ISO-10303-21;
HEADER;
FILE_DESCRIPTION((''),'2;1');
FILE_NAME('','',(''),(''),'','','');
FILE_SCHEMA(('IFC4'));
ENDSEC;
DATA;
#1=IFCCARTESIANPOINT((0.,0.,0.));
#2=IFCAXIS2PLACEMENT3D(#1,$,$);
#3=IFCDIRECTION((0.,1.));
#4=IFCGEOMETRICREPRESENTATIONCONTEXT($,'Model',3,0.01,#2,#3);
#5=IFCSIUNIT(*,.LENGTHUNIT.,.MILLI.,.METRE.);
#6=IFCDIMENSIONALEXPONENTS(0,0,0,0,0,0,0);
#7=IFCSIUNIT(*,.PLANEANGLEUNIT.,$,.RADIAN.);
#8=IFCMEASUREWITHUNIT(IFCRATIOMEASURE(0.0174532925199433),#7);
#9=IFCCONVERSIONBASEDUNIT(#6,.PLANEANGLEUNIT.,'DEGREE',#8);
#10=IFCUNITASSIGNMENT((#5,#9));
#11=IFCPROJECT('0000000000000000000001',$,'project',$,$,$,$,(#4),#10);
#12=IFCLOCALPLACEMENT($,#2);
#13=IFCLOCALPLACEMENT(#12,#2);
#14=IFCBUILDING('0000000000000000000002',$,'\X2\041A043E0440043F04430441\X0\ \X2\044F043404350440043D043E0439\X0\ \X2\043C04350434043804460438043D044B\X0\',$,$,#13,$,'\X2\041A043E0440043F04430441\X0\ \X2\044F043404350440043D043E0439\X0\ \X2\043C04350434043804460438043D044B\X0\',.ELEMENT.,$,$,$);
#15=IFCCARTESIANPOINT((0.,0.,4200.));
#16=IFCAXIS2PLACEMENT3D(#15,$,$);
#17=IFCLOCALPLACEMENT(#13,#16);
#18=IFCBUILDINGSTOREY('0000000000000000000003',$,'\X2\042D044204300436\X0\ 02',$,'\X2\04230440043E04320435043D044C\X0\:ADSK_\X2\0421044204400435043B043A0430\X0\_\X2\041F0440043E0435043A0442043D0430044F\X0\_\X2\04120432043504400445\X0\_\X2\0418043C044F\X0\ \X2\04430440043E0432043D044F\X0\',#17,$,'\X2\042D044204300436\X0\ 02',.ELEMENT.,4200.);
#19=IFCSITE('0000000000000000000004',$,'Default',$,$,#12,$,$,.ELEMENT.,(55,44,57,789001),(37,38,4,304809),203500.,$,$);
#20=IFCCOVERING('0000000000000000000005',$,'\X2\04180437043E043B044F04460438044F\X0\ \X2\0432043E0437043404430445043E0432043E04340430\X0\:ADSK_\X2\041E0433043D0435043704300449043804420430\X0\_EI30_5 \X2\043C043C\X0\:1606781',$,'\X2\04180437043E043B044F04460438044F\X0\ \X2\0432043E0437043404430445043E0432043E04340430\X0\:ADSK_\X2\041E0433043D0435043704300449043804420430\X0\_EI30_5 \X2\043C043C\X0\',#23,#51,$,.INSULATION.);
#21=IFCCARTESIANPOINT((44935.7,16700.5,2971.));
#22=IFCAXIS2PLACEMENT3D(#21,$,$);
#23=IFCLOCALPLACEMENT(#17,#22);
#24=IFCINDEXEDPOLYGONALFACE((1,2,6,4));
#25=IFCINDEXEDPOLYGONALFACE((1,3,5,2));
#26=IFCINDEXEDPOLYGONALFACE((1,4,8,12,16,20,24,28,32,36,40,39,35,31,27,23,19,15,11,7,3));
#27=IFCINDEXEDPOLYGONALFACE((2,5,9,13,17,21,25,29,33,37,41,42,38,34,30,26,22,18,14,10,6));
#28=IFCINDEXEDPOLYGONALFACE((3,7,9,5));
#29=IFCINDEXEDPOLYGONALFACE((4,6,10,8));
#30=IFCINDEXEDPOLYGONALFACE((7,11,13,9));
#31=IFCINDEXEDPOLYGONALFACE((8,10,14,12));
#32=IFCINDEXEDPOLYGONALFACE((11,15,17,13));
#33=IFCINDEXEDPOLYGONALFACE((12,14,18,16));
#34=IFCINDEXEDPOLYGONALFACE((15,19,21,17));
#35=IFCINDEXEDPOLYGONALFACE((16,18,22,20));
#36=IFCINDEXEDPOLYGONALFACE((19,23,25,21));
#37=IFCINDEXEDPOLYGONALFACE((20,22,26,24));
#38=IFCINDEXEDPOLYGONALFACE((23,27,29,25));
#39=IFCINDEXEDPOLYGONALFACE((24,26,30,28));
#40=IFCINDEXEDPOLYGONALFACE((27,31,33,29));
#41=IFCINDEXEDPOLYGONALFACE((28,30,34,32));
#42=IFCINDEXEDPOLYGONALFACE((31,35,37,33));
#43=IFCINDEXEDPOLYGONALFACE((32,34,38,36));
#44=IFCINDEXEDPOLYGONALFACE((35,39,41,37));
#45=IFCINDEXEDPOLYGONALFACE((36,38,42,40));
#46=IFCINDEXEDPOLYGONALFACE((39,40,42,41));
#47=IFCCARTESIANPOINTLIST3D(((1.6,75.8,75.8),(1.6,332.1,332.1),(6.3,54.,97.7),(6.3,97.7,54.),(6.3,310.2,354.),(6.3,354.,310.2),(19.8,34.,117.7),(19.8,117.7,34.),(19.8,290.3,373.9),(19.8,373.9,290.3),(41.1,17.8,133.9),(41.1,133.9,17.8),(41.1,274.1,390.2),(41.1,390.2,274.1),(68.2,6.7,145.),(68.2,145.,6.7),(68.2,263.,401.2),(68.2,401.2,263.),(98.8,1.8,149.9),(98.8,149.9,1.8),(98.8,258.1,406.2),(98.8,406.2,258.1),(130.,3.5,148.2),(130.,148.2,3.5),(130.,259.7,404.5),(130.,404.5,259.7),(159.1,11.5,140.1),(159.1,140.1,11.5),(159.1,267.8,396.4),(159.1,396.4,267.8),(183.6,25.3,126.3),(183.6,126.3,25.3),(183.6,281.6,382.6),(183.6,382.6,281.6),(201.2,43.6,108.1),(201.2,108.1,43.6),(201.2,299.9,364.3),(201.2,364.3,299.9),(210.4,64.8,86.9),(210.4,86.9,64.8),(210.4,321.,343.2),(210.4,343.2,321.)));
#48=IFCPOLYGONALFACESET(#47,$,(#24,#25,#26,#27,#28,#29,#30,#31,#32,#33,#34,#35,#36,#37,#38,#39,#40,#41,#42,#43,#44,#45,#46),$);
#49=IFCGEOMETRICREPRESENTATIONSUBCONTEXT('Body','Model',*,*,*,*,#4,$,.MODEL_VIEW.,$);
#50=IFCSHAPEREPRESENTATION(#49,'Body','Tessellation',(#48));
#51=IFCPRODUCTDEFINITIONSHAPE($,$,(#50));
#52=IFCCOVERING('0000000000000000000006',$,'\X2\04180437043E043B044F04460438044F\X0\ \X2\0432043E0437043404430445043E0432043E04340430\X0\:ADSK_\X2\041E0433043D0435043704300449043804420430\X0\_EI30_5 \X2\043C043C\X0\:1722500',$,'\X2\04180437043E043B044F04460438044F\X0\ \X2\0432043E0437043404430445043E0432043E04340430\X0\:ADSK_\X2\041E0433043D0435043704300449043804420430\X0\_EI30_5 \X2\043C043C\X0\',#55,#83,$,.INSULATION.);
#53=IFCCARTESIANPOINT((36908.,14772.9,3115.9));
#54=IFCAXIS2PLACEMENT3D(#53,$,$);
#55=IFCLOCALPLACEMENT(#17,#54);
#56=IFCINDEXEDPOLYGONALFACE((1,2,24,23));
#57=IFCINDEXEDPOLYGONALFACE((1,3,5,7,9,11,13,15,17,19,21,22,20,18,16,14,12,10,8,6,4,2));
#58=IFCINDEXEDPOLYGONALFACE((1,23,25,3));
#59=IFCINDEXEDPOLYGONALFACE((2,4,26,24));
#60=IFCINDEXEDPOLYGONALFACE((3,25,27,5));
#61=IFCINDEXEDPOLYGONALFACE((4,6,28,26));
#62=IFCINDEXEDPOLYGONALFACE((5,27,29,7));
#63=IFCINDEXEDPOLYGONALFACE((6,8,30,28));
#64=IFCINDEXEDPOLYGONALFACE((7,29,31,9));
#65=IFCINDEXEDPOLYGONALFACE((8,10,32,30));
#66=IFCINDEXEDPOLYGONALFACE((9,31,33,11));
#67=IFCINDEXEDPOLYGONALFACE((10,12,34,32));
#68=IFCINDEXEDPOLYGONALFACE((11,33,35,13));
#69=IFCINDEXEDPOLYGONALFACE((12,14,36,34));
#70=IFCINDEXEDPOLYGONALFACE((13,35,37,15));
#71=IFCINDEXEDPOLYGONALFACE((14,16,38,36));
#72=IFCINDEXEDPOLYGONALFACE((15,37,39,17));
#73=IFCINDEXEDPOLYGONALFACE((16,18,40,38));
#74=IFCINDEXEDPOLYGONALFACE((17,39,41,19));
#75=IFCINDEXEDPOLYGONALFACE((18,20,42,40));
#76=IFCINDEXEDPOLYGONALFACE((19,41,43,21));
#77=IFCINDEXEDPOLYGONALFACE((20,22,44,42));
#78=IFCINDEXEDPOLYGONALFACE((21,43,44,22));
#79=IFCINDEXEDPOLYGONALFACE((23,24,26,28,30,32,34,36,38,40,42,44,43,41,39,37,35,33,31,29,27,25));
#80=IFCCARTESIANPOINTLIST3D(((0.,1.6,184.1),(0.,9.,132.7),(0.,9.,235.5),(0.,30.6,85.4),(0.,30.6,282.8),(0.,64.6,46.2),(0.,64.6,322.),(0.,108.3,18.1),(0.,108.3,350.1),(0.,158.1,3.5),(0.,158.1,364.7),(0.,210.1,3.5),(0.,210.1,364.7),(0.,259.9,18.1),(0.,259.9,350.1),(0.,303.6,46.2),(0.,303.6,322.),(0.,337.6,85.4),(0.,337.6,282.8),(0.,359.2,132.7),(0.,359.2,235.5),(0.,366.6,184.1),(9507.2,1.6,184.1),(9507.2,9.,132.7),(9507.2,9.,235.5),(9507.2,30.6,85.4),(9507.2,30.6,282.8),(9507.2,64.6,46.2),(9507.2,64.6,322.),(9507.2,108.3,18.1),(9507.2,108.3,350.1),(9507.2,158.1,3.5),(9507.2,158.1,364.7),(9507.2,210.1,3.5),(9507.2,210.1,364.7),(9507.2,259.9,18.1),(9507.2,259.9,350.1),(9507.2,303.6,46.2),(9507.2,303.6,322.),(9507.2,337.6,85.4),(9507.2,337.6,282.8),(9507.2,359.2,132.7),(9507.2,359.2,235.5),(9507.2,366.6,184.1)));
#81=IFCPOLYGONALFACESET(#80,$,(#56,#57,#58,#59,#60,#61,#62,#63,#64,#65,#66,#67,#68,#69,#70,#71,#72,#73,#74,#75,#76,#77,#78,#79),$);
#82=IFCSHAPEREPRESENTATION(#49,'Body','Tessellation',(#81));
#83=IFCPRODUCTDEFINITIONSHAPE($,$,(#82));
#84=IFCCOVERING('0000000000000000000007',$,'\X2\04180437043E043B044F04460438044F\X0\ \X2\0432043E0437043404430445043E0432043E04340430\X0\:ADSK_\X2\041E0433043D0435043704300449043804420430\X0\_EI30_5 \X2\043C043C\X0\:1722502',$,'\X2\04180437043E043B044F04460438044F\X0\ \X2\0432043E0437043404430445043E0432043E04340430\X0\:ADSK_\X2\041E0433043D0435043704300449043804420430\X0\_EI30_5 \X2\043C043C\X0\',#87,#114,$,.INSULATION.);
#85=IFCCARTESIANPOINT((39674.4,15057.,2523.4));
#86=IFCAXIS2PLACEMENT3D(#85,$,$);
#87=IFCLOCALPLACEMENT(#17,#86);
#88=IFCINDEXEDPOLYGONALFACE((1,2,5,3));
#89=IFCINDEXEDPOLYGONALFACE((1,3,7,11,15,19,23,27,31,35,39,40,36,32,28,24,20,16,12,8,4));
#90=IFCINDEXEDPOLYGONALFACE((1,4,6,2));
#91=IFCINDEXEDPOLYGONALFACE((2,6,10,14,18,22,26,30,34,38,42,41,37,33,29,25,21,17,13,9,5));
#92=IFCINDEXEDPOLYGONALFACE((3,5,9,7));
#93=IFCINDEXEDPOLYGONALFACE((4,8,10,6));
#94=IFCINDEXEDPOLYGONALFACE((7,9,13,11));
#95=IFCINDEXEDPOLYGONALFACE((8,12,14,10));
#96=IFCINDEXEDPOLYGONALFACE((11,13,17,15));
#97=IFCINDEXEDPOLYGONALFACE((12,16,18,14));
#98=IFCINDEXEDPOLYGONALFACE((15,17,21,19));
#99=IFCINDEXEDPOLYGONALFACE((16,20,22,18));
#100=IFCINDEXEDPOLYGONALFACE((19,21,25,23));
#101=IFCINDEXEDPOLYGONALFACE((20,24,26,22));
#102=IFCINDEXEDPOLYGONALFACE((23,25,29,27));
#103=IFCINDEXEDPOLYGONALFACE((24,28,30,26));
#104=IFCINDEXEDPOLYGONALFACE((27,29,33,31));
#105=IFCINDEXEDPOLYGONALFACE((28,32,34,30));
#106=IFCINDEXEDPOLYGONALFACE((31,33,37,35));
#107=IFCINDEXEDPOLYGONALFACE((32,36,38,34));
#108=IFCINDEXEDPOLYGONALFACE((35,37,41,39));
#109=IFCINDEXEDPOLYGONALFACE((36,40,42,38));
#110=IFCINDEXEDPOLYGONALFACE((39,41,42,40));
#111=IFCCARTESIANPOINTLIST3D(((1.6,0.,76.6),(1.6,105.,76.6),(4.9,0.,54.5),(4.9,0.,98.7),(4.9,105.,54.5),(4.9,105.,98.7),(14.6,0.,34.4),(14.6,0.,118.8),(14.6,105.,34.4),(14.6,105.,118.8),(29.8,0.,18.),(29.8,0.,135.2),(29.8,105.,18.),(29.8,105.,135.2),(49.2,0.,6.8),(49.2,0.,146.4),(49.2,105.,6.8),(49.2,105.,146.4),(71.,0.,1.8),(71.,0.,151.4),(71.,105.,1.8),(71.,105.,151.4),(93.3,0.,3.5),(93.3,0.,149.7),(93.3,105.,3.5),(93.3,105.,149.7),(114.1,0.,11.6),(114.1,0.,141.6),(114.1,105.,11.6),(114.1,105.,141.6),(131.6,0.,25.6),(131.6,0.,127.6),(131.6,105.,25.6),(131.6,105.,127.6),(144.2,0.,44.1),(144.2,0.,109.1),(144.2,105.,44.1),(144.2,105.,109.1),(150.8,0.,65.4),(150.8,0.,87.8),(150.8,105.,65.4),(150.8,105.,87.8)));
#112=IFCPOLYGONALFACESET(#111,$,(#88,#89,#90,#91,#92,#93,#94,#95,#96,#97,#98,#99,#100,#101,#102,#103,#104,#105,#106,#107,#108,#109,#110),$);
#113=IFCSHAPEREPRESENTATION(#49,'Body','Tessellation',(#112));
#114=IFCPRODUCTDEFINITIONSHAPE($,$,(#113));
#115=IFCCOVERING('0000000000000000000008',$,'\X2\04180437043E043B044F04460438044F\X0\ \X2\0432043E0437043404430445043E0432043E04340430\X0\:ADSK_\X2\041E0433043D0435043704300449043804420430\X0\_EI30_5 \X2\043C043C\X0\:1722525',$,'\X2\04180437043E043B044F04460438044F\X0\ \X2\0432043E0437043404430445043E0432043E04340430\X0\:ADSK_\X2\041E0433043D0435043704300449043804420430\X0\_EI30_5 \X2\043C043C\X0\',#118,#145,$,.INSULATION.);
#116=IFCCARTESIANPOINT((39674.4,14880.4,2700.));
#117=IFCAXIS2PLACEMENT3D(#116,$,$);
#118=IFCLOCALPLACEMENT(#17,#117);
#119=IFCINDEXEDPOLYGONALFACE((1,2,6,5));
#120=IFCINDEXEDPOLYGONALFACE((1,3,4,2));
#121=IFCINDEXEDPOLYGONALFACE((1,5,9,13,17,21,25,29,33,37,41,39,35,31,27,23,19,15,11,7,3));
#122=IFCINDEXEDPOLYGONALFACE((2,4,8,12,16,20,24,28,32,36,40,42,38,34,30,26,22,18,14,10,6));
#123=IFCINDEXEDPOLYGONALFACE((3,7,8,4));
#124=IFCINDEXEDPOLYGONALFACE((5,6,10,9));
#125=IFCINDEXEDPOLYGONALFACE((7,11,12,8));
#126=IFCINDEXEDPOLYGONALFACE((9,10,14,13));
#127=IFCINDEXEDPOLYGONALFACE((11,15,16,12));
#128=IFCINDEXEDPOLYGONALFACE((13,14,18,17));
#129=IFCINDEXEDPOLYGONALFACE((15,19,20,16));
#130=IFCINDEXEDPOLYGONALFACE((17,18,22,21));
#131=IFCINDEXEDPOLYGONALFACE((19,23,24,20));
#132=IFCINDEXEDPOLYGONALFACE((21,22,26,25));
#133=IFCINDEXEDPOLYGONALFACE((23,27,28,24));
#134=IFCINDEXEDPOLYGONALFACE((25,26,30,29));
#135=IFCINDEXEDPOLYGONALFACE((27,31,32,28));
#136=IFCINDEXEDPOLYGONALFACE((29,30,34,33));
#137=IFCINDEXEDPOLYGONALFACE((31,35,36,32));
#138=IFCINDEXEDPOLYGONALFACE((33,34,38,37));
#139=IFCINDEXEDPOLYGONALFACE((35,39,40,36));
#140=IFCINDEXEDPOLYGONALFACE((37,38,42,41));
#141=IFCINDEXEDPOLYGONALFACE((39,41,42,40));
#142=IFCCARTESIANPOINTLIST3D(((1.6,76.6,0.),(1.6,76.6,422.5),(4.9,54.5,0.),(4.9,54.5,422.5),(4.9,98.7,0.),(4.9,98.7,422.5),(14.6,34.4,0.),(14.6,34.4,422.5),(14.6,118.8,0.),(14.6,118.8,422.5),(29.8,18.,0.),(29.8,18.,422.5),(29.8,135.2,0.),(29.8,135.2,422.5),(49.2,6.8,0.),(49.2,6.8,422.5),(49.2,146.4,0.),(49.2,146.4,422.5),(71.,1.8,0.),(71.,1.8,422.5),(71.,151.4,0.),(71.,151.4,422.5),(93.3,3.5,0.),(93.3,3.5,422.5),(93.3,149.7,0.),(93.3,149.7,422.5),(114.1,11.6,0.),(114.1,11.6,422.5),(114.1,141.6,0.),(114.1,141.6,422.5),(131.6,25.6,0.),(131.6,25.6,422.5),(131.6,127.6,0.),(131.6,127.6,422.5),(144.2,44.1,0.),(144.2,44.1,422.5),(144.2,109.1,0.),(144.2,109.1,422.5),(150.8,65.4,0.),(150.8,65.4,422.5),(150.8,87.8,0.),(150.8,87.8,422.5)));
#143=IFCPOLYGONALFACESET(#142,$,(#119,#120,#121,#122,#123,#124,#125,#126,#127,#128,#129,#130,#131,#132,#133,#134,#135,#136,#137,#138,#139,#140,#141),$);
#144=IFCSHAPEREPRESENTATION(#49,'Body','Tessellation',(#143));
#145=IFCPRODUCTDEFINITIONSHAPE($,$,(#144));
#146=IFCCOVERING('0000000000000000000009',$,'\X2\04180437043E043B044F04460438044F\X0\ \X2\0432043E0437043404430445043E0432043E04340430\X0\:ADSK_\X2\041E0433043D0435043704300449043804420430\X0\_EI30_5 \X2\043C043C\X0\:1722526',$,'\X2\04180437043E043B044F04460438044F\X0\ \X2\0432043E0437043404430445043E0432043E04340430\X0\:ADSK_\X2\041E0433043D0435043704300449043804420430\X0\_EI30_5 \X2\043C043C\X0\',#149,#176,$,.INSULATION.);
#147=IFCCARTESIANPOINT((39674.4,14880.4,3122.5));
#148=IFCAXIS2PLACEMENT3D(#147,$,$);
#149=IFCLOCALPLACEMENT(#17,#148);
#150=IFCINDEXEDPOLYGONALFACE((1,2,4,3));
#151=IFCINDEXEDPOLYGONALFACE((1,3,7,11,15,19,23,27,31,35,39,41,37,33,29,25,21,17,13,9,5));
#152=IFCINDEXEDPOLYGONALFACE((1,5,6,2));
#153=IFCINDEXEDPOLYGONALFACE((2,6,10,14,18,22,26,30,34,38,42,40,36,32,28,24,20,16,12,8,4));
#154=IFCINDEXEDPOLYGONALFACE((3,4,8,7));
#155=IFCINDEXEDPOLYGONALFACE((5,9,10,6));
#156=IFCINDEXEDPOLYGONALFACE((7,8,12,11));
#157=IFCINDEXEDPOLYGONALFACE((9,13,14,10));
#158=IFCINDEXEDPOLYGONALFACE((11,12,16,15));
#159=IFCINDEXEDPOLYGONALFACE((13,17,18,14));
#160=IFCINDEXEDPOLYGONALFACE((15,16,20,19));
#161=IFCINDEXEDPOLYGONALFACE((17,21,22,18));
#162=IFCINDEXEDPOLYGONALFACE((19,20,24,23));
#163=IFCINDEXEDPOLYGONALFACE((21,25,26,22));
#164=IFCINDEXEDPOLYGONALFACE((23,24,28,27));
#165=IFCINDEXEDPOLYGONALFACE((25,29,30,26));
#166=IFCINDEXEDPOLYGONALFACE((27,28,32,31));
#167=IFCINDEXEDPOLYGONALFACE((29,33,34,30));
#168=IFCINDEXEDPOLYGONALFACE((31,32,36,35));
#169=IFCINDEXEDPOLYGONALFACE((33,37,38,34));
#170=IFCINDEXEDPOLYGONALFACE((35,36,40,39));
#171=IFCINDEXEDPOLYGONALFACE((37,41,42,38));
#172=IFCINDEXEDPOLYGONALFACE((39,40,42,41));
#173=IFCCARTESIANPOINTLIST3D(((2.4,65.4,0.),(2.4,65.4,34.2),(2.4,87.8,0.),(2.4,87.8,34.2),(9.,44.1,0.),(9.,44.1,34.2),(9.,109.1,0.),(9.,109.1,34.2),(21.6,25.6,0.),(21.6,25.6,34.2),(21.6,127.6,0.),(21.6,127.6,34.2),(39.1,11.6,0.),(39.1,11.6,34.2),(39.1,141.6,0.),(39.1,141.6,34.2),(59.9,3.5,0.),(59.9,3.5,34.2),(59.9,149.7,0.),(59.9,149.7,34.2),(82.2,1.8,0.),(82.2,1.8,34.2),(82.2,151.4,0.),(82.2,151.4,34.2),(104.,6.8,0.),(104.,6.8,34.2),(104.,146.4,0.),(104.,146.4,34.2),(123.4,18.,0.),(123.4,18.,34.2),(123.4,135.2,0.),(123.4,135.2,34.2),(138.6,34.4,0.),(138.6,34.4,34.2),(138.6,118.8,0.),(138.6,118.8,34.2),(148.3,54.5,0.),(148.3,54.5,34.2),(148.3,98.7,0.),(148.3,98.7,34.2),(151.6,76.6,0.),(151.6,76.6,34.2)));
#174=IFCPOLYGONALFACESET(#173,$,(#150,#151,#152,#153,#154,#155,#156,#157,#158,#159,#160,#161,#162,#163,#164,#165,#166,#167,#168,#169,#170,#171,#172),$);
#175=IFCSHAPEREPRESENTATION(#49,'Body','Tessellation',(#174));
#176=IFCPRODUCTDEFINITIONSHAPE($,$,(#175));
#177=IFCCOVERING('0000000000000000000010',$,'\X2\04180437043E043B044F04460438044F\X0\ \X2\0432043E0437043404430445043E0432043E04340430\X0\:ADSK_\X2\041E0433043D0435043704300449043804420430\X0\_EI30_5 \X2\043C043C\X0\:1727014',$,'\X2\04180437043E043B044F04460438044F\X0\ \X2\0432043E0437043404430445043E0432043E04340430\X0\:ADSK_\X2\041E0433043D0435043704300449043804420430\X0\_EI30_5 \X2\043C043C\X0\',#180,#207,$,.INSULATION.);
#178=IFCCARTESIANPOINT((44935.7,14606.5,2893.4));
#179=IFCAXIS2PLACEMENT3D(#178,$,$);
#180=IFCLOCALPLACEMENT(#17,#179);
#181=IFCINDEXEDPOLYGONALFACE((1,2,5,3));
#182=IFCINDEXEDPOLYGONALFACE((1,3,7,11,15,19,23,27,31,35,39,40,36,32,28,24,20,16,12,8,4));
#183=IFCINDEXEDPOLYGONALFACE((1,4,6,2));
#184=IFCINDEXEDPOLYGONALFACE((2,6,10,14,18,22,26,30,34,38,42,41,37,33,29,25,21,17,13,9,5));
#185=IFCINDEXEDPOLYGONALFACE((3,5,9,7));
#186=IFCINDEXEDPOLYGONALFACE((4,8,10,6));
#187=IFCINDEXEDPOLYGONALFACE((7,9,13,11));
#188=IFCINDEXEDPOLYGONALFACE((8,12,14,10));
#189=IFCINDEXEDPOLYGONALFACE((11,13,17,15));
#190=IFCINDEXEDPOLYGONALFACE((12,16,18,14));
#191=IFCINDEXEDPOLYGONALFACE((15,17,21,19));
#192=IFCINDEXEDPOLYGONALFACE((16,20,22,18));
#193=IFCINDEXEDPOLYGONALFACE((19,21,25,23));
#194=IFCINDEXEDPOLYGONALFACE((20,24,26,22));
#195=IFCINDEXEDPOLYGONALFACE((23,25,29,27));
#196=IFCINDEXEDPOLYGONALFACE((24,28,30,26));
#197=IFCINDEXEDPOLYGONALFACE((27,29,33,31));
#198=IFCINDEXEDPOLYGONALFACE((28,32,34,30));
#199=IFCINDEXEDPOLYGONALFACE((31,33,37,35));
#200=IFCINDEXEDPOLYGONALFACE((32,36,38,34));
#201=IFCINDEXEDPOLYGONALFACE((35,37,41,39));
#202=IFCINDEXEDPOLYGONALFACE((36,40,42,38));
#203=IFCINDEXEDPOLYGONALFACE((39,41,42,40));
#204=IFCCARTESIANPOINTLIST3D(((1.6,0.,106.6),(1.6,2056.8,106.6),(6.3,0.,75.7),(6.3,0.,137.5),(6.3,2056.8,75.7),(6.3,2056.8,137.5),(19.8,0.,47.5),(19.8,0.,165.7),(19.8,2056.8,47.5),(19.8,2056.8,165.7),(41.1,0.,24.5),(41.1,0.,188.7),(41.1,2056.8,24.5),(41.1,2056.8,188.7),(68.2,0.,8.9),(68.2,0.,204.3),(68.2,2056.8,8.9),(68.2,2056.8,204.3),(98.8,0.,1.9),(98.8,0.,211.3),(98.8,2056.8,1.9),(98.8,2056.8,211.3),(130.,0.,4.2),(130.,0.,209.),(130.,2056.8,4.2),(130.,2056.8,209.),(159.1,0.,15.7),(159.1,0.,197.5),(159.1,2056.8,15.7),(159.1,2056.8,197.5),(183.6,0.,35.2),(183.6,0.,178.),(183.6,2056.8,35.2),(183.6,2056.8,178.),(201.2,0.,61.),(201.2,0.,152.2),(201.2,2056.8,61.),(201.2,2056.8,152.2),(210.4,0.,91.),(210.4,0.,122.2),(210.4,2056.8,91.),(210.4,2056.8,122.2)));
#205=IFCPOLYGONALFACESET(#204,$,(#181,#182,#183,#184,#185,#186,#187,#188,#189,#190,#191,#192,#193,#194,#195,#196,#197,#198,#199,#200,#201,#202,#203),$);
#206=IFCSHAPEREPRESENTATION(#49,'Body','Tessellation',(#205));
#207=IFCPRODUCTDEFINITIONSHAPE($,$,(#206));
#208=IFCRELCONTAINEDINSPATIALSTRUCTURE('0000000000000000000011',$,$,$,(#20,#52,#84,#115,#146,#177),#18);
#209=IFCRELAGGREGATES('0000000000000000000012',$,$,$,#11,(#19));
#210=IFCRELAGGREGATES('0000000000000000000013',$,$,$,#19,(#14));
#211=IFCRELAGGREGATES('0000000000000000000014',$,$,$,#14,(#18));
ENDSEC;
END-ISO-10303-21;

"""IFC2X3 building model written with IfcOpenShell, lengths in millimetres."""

from ifc_helpers import new_model, entity, si_unit, converted_unit, direction, frame, origin, origin_2d_with_axis, place, context, subcontext, project, spatial, circle, extrude, element, save


model = new_model("IFC2X3")

# Units and contexts
model_context = context("Model", 3, precision=0.01, world=origin(), true_north=direction((0.0, 1.0)))
body_context = subcontext(model_context, "Body", "Model", "MODEL_VIEW")
ifc_project = project(units=[si_unit("LENGTHUNIT", "METRE", prefix="MILLI"), converted_unit("PLANEANGLEUNIT", "DEGREE", entity("IfcRatioMeasure", 0.0174532925199433), si_unit("PLANEANGLEUNIT", "RADIAN"), dimensions=[0, 0, 0, 0, 0, 0, 0])], contexts=[model_context])

# Site, building, storey
site_placement = place(None, origin())
site = spatial("IfcSite", under=ifc_project, at=site_placement, Name="Default", CompositionType="ELEMENT", RefLatitude=(55, 44, 57, 789001), RefLongitude=(37, 38, 4, 304809), RefElevation=203500.0)
building_placement = place(site_placement, origin())
building = spatial("IfcBuilding", under=site, at=building_placement, Name="Корпус ядерной медицины", LongName="Корпус ядерной медицины", CompositionType="ELEMENT")
storey_placement = place(building_placement, frame((0.0, 0.0, 4200.0)))
storey = spatial("IfcBuildingStorey", under=building, at=storey_placement, Name="Этаж 02", ObjectType="Уровень:ADSK_Стрелка_Проектная_Вверх_Имя уровня", LongName="Этаж 02", CompositionType="ELEMENT", Elevation=4200.0)

# Coverings
covering_1_placement = place(storey_placement, frame((44935.7, 16700.5, 2971.0)))
element("IfcCovering", 1, at=covering_1_placement, inside=storey, Name="Изоляция воздуховода:ADSK_Огнезащита_EI30_5 мм:1606781", ObjectType="Изоляция воздуховода:ADSK_Огнезащита_EI30_5 мм", PredefinedType="INSULATION", context=body_context, shape_type="SweptSolid", body=[
    extrude(circle(Radius=105.0, at=origin_2d_with_axis()), frame((106.6, 75.8, 75.8), z_axis=(0.0, 0.707107, 0.707107), x_axis=(-1.0, 0.0, 0.0)), (0.0, 0.0, 1.0), 362.4),
])
covering_2_placement = place(storey_placement, frame((36908.0, 14772.9, 3115.9)))
element("IfcCovering", 2, at=covering_2_placement, inside=storey, Name="Изоляция воздуховода:ADSK_Огнезащита_EI30_5 мм:1722500", ObjectType="Изоляция воздуховода:ADSK_Огнезащита_EI30_5 мм", PredefinedType="INSULATION", context=body_context, shape_type="SweptSolid", body=[
    extrude(circle(Radius=182.5, at=origin_2d_with_axis()), frame((0.0, 184.1, 184.1), z_axis=(1.0, 0.0, 0.0), x_axis=(0.0, -1.0, 0.0)), (0.0, 0.0, 1.0), 9507.2),
])
covering_3_placement = place(storey_placement, frame((39674.4, 15057.0, 2523.4)))
element("IfcCovering", 3, at=covering_3_placement, inside=storey, Name="Изоляция воздуховода:ADSK_Огнезащита_EI30_5 мм:1722502", ObjectType="Изоляция воздуховода:ADSK_Огнезащита_EI30_5 мм", PredefinedType="INSULATION", context=body_context, shape_type="SweptSolid", body=[
    extrude(circle(Radius=75.0, at=origin_2d_with_axis()), frame((76.6, 0.0, 76.6), z_axis=(0.0, 1.0, 0.0), x_axis=(-1.0, 0.0, 0.0)), (0.0, 0.0, 1.0), 105.0),
])
covering_4_placement = place(storey_placement, frame((39674.4, 14880.4, 2700.0)))
element("IfcCovering", 4, at=covering_4_placement, inside=storey, Name="Изоляция воздуховода:ADSK_Огнезащита_EI30_5 мм:1722525", ObjectType="Изоляция воздуховода:ADSK_Огнезащита_EI30_5 мм", PredefinedType="INSULATION", context=body_context, shape_type="SweptSolid", body=[
    extrude(circle(Radius=75.0, at=origin_2d_with_axis()), frame((76.6, 76.6, 0.0), z_axis=(0.0, 0.0, 1.0), x_axis=(-1.0, 0.0, 0.0)), (0.0, 0.0, 1.0), 422.5),
])
covering_5_placement = place(storey_placement, frame((39674.4, 14880.4, 3122.5)))
element("IfcCovering", 5, at=covering_5_placement, inside=storey, Name="Изоляция воздуховода:ADSK_Огнезащита_EI30_5 мм:1722526", ObjectType="Изоляция воздуховода:ADSK_Огнезащита_EI30_5 мм", PredefinedType="INSULATION", context=body_context, shape_type="SweptSolid", body=[
    extrude(circle(Radius=75.0, at=origin_2d_with_axis()), frame((76.6, 76.6, 0.0)), (0.0, 0.0, 1.0), 34.2),
])
covering_6_placement = place(storey_placement, frame((44935.7, 14606.5, 2893.4)))
element("IfcCovering", 6, at=covering_6_placement, inside=storey, Name="Изоляция воздуховода:ADSK_Огнезащита_EI30_5 мм:1727014", ObjectType="Изоляция воздуховода:ADSK_Огнезащита_EI30_5 мм", PredefinedType="INSULATION", context=body_context, shape_type="SweptSolid", body=[
    extrude(circle(Radius=105.0, at=origin_2d_with_axis()), frame((106.6, 0.0, 106.6), z_axis=(0.0, 1.0, 0.0), x_axis=(-1.0, 0.0, 0.0)), (0.0, 0.0, 1.0), 2056.8),
])

save(model, "model.ifc")
